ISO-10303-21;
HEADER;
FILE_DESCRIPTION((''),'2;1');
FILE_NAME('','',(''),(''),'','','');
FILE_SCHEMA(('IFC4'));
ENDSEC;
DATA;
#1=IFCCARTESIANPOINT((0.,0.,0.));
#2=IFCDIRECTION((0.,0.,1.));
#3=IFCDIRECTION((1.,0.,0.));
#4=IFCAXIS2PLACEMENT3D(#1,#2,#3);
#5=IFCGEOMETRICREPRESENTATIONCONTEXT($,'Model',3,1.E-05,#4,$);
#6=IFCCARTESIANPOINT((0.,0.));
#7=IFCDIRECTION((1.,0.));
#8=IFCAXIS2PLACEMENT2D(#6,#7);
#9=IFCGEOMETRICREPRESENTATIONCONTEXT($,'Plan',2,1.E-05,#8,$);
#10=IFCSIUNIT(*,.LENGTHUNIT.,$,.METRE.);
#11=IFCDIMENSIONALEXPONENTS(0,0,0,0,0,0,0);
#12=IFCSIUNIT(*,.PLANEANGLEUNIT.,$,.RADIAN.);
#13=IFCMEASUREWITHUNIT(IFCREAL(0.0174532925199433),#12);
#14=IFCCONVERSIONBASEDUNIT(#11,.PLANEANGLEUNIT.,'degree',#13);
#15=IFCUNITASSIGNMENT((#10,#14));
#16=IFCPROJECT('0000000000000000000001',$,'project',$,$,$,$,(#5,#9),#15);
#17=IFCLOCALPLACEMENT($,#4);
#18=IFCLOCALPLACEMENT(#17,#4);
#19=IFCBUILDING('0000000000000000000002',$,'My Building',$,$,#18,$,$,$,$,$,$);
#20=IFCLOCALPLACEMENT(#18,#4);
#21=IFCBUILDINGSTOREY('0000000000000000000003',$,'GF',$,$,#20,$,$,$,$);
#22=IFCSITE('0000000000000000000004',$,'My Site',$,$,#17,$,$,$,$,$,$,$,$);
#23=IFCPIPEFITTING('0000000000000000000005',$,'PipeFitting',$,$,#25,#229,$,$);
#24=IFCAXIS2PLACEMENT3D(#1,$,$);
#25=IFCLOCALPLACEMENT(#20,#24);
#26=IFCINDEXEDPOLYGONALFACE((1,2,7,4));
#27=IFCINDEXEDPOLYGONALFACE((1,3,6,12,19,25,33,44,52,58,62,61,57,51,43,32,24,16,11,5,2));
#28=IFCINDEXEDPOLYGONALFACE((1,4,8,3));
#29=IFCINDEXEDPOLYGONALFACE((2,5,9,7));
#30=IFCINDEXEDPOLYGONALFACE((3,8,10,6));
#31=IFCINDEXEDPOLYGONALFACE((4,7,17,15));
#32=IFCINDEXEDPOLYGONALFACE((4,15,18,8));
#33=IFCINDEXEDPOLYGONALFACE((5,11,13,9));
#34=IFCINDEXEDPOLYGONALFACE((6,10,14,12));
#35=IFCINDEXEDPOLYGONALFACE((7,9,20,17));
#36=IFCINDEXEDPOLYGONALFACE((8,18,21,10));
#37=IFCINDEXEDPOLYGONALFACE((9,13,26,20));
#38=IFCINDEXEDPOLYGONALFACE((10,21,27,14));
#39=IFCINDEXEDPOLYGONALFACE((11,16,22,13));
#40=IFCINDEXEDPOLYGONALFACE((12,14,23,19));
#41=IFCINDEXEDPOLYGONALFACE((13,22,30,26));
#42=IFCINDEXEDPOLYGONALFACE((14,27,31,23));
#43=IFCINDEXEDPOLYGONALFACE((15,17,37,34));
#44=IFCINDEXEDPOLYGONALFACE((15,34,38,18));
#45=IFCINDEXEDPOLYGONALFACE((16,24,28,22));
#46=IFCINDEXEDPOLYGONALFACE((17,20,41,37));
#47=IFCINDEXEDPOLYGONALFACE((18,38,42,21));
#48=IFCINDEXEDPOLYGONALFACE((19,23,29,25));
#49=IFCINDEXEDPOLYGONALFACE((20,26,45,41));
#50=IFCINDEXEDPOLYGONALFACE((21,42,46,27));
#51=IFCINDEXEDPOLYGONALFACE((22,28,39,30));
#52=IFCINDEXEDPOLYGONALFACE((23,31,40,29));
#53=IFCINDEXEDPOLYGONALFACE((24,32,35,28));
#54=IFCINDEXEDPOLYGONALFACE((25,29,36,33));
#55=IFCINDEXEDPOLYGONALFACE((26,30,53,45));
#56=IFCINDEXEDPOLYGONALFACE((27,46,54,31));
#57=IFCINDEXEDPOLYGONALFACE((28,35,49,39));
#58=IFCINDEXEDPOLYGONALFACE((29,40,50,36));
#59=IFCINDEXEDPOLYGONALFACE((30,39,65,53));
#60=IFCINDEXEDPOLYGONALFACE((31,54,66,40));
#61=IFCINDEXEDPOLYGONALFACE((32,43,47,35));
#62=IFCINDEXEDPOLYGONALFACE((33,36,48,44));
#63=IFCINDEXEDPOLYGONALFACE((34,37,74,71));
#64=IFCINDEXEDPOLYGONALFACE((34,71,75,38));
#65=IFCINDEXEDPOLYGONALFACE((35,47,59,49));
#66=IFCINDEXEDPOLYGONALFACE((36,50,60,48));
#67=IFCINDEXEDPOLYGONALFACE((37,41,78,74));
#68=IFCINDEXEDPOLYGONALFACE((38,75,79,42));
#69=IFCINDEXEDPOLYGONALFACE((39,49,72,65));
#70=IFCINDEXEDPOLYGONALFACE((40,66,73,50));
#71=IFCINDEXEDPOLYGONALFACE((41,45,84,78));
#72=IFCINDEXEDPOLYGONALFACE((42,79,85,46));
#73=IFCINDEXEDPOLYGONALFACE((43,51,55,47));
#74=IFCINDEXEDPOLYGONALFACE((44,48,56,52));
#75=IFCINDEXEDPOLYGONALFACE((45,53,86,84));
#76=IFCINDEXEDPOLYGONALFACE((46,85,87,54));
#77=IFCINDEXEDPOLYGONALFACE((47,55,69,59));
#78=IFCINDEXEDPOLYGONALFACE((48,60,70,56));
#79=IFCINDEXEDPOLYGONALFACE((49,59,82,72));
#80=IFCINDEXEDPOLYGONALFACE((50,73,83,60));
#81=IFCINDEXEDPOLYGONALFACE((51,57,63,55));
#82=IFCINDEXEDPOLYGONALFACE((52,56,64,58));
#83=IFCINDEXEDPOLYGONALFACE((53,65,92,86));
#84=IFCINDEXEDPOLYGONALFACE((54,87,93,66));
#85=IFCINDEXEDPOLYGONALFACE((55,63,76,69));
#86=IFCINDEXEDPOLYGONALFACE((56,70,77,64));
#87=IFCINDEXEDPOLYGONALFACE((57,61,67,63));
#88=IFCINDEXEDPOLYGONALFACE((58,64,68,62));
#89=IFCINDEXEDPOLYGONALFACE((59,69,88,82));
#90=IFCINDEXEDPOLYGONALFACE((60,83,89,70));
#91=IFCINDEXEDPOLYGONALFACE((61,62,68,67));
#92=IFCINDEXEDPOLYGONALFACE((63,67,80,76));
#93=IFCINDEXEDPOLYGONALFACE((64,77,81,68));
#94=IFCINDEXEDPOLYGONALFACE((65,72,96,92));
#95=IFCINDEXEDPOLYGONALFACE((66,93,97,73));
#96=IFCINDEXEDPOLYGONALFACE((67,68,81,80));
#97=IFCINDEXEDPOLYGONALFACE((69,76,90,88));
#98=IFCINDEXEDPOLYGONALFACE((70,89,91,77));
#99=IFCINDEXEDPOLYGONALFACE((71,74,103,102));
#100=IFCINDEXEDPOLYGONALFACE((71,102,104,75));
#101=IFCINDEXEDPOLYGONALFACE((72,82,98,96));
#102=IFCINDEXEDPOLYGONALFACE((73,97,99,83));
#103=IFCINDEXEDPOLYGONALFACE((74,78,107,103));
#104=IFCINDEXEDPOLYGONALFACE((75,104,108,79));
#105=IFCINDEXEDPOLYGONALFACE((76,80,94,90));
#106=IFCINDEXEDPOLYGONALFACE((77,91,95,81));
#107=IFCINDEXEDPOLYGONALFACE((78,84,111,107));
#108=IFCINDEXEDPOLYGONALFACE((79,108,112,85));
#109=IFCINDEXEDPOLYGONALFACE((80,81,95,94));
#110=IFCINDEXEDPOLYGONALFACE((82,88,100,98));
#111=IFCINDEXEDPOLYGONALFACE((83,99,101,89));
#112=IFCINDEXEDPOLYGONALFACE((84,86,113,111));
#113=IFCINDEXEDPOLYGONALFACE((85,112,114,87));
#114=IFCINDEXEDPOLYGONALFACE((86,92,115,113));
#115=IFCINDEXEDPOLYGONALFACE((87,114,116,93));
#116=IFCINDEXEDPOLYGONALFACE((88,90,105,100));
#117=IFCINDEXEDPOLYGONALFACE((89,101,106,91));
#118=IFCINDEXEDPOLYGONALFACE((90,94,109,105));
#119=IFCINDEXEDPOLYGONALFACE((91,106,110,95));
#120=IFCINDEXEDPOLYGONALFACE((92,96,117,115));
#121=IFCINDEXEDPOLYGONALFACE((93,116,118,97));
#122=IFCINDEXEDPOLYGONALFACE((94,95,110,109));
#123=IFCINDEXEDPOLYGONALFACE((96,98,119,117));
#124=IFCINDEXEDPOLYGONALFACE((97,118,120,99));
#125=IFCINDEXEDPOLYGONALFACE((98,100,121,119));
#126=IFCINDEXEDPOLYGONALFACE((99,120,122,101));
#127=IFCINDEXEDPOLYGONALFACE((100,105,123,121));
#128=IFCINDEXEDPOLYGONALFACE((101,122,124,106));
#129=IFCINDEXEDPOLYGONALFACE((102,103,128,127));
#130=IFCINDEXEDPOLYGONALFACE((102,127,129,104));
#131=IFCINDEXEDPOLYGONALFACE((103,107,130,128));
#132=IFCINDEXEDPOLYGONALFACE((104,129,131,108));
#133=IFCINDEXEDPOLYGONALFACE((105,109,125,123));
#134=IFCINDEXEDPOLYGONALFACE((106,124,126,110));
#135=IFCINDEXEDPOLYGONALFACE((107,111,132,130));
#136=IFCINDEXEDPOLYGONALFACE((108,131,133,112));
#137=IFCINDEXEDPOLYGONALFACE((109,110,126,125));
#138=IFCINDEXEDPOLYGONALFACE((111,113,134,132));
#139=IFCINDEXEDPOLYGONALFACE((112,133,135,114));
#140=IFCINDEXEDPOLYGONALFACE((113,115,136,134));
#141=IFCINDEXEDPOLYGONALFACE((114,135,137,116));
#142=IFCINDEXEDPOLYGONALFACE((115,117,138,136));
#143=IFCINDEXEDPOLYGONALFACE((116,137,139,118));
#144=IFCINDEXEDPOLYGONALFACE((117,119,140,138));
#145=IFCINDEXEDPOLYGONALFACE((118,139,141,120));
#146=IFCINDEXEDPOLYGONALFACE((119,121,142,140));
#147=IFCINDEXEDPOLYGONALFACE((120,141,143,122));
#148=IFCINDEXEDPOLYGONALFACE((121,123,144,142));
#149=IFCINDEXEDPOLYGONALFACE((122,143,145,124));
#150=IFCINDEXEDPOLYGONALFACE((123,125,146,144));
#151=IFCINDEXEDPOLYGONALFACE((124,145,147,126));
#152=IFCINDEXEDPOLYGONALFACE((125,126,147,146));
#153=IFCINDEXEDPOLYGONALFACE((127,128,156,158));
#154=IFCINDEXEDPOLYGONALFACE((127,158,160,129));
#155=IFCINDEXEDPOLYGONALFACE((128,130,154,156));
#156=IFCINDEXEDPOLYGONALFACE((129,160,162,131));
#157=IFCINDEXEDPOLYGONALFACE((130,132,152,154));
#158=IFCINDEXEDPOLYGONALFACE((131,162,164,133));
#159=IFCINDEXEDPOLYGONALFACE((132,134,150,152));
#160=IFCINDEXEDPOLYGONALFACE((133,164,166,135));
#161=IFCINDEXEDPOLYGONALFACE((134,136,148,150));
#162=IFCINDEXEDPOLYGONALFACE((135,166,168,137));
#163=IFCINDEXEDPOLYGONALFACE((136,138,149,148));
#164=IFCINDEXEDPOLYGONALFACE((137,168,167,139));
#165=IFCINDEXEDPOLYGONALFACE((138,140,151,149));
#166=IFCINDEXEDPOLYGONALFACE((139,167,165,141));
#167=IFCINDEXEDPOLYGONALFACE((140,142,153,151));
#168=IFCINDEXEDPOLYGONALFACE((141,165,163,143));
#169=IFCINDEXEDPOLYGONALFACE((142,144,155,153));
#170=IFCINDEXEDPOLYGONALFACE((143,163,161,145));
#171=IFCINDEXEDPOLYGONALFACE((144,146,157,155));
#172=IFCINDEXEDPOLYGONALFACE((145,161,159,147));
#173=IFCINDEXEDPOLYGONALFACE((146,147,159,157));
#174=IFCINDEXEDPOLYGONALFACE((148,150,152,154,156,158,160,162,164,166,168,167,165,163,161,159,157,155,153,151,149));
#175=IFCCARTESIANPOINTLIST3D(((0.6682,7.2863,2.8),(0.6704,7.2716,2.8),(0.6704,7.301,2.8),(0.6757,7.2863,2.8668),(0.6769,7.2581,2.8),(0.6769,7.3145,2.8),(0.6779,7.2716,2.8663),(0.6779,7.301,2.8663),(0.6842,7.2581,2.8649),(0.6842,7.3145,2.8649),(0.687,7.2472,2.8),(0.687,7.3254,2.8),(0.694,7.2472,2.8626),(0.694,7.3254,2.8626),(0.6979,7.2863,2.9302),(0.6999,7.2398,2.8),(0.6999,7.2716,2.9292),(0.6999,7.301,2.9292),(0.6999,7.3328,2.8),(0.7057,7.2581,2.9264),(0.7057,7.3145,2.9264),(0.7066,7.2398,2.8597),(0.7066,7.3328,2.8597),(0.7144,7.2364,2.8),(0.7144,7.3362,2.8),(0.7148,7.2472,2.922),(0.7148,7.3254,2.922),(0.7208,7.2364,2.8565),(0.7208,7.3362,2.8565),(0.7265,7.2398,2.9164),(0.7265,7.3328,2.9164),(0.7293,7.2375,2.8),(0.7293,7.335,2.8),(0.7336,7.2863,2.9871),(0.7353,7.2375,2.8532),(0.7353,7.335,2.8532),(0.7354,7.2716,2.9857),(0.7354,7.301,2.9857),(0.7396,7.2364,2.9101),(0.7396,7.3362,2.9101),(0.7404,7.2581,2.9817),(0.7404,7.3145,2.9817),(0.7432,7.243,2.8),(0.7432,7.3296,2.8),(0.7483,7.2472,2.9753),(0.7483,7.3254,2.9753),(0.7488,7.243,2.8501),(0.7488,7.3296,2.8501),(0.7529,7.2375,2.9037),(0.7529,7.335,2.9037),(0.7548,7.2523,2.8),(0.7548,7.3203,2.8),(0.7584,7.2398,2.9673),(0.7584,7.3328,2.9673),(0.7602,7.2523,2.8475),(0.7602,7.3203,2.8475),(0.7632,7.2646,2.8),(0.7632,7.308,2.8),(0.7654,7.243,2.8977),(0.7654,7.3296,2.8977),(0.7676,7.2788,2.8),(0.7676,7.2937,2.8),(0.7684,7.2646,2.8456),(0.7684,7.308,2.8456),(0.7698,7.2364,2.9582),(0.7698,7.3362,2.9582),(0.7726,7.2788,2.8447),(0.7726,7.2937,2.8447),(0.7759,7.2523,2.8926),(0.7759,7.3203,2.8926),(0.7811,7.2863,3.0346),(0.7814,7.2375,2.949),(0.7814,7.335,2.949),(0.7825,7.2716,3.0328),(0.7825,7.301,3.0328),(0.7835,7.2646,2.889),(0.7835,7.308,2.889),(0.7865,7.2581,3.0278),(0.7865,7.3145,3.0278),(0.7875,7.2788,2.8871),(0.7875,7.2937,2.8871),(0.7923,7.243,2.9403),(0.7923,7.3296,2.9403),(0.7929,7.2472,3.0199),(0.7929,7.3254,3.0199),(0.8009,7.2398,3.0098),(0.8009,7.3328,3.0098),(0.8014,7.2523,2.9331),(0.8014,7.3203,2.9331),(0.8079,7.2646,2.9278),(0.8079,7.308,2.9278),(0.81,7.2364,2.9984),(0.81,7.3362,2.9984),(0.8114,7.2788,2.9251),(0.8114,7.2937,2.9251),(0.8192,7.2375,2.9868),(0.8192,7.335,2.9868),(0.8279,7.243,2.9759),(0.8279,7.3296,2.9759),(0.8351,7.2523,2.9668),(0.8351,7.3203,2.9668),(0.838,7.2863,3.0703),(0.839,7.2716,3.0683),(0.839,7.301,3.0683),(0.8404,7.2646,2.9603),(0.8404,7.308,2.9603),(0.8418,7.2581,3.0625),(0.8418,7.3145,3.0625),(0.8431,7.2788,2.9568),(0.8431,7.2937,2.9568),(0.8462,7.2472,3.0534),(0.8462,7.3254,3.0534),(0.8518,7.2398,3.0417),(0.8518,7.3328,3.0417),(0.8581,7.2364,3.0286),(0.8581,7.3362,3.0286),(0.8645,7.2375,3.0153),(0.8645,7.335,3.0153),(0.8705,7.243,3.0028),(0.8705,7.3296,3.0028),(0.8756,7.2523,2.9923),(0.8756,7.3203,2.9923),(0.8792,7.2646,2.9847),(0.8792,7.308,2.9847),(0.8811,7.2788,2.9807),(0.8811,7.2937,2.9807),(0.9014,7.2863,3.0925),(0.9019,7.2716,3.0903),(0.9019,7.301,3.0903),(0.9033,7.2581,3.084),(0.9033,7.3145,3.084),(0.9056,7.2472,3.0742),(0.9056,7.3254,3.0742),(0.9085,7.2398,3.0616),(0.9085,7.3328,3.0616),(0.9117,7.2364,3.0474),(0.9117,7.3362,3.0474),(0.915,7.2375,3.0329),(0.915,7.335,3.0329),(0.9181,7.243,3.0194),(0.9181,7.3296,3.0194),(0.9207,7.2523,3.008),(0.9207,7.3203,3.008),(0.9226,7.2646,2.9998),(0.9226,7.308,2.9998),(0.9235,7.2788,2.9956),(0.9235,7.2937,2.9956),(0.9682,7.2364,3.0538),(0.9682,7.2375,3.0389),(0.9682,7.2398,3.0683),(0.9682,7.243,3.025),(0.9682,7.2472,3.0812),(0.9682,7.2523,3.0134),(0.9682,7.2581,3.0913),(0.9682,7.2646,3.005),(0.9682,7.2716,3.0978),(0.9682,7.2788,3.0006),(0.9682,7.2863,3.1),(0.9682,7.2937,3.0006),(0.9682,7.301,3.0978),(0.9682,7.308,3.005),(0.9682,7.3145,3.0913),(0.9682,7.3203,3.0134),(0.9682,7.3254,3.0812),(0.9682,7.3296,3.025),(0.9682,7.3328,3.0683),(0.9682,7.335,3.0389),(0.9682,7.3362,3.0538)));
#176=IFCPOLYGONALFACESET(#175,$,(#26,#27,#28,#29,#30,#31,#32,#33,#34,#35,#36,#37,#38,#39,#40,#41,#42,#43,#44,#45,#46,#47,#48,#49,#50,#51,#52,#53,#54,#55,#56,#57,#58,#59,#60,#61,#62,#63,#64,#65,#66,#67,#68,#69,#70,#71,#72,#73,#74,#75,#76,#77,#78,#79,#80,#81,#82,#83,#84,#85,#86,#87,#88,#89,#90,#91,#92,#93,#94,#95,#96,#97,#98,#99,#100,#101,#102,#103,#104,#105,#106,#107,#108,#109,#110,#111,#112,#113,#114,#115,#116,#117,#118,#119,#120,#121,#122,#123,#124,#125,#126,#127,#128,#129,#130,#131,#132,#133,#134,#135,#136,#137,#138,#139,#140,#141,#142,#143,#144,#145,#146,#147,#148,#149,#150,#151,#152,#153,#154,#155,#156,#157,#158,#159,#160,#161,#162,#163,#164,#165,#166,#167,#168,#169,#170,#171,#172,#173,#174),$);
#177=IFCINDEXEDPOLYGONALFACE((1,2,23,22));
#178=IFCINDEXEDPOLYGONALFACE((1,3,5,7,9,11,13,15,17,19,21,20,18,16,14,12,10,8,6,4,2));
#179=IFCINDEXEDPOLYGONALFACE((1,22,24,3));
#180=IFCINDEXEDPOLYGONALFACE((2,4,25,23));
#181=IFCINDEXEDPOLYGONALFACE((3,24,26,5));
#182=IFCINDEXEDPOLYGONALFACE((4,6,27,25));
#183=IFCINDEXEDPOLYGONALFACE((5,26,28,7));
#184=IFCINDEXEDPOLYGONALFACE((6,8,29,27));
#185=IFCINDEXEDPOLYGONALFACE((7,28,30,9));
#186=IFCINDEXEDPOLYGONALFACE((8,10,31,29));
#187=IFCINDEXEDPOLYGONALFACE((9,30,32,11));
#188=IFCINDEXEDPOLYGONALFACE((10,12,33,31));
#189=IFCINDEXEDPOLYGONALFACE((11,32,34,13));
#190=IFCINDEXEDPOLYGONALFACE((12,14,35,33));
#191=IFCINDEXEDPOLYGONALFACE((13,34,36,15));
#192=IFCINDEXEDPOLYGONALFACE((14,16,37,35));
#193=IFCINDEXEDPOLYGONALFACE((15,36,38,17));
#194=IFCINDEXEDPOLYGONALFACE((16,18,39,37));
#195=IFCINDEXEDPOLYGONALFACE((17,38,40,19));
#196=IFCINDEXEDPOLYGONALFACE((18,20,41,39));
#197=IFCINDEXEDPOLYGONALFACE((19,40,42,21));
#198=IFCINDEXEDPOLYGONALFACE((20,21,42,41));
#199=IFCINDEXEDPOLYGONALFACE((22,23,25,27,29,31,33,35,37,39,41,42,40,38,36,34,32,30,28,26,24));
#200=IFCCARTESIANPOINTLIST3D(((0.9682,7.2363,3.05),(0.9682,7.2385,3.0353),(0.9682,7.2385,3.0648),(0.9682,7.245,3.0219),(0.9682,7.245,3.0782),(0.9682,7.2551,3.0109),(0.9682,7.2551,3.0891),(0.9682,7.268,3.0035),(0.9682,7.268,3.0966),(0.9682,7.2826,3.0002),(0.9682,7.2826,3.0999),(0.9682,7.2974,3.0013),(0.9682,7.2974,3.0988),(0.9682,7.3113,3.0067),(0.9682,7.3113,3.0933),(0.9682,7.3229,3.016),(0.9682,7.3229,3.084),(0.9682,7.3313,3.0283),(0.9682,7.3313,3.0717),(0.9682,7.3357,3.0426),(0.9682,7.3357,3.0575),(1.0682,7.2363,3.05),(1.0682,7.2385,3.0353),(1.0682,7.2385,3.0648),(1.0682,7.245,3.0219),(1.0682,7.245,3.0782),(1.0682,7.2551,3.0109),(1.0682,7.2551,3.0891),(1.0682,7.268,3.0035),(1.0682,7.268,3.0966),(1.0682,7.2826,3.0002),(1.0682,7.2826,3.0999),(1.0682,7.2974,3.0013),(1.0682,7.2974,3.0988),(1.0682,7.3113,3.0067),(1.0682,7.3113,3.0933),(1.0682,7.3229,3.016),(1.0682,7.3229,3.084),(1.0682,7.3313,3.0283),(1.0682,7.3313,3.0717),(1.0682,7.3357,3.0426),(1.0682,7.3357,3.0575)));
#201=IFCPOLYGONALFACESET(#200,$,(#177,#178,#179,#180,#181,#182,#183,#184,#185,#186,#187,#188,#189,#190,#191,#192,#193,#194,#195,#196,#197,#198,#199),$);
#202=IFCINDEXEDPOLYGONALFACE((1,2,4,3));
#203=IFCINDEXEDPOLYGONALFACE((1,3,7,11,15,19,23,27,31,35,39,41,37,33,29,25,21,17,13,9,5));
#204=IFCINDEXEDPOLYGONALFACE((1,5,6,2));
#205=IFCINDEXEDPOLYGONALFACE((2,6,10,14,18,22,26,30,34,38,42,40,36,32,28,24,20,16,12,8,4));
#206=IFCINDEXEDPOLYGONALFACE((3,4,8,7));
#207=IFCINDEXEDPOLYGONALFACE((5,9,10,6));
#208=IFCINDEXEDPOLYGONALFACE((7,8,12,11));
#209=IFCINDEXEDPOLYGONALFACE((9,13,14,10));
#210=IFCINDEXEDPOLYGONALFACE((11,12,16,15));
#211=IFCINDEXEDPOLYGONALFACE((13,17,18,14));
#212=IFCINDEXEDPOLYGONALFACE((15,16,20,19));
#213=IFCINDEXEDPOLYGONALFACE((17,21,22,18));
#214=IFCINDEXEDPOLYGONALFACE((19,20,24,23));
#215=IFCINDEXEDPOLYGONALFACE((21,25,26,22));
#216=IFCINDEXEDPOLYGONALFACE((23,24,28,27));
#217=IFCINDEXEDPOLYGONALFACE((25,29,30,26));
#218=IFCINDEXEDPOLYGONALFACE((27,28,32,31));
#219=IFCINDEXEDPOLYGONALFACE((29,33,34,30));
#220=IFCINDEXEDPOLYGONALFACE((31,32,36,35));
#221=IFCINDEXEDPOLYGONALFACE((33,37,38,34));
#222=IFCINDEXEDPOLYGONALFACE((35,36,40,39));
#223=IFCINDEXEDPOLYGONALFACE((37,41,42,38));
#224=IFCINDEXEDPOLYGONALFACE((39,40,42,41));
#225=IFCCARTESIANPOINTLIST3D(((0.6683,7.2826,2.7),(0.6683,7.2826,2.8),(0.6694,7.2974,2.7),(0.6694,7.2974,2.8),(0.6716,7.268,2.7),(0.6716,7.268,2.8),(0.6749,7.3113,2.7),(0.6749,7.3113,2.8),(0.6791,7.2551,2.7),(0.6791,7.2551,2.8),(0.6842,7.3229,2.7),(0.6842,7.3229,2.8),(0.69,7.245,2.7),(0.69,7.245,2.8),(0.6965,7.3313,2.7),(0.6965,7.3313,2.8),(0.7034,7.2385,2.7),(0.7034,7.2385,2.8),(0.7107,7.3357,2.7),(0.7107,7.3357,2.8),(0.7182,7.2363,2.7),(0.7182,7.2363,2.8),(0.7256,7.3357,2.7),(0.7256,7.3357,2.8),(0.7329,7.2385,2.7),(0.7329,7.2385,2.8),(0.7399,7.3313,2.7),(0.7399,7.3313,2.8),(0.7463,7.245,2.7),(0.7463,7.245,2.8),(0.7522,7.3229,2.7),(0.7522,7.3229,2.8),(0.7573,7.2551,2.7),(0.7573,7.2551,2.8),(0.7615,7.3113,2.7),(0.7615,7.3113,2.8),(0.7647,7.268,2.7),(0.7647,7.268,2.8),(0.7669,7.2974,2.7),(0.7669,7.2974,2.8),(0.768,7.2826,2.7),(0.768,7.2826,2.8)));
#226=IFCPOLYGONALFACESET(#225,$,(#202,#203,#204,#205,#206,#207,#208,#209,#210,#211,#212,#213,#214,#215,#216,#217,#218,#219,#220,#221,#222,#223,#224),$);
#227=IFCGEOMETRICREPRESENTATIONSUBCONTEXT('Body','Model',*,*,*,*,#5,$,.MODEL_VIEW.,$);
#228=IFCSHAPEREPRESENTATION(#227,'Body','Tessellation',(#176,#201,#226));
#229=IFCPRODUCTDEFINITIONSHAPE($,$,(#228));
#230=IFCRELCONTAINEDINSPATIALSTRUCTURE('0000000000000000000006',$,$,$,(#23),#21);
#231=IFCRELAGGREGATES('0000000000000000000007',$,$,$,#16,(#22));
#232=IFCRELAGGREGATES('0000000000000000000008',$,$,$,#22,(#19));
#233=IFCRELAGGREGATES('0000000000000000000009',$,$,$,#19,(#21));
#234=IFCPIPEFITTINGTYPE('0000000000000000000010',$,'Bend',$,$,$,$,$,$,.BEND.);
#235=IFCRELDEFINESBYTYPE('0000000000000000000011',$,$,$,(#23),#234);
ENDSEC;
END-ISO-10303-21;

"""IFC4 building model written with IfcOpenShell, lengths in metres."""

from ifc_helpers import new_model, entity, si_unit, converted_unit, frame, origin_with_axes, origin_2d_with_axis, place, context, subcontext, project, spatial, circle, extrude, source, transform, mapped, type_object, type_shapes, element, save


model = new_model("IFC4")

# Units and contexts
model_context = context("Model", 3, precision=1e-05, world=origin_with_axes())
plan_context = context("Plan", 2, precision=1e-05, world=origin_2d_with_axis())
body_context_1 = subcontext(model_context, "Body", "Model", "MODEL_VIEW")
ifc_project = project(units=[si_unit("LENGTHUNIT", "METRE"), converted_unit("PLANEANGLEUNIT", "degree", entity("IfcReal", 0.0174532925199433), si_unit("PLANEANGLEUNIT", "RADIAN"), dimensions=[0, 0, 0, 0, 0, 0, 0])], contexts=[model_context, plan_context])

# Site, building, storey
site_placement = place(None, origin_with_axes())
site = spatial("IfcSite", under=ifc_project, at=site_placement, Name="My Site")
building_placement = place(site_placement, origin_with_axes())
building = spatial("IfcBuilding", under=site, at=building_placement, Name="My Building")
storey_placement = place(building_placement, origin_with_axes())
storey = spatial("IfcBuildingStorey", under=building, at=storey_placement, Name="GF")

# Pipe fitting
pipe_fitting_type = type_object("IfcPipeFittingType", Name="Bend", PredefinedType="BEND")
shared_shape_1 = source(origin_with_axes(), body_context_1, "Body", "SolidModel", [
    entity("IfcSweptDiskSolid", entity("IfcIndexedPolyCurve", entity("IfcCartesianPointList3D", [[0.0, 0.0, 0.1], [0.0, -0.0732, 0.2768], [0.0, -0.25, 0.35]]), [entity("IfcArcIndex", [1, 2, 3])]), 0.05),
    extrude(circle(Radius=0.05), origin_with_axes(), (0.0, 0.0, 1.0), 0.1),
    extrude(circle(Radius=0.05), frame((0.0, -0.25, 0.35), z_axis=(0.0, -1.0, 0.0), x_axis=(1.0, 0.0, 0.0)), (0.0, 0.0, 1.0), 0.1),
])
type_shapes(pipe_fitting_type, [shared_shape_1])
for number, where, z_axis, x_axis, name in (
    (1, (1.0682, 7.2863, 3.05), (-1.0, 0.0, 0.0), (0.0, -1.0, 0.0), "PipeFitting"),
):
    element("IfcPipeFitting", number, at=place(storey_placement, frame(where, z_axis=z_axis, x_axis=x_axis)), inside=storey, type_object=pipe_fitting_type, Name=name, context=body_context_1, shape_type="MappedRepresentation", body=[
        mapped(shared_shape_1, transform((0.0, 0.0, 0.0), x_axis=(1.0, 0.0, 0.0), y_axis=(0.0, 1.0, 0.0), z_axis=(0.0, 0.0, 1.0), scale=1.0)),
    ])

save(model, "model.ifc")
